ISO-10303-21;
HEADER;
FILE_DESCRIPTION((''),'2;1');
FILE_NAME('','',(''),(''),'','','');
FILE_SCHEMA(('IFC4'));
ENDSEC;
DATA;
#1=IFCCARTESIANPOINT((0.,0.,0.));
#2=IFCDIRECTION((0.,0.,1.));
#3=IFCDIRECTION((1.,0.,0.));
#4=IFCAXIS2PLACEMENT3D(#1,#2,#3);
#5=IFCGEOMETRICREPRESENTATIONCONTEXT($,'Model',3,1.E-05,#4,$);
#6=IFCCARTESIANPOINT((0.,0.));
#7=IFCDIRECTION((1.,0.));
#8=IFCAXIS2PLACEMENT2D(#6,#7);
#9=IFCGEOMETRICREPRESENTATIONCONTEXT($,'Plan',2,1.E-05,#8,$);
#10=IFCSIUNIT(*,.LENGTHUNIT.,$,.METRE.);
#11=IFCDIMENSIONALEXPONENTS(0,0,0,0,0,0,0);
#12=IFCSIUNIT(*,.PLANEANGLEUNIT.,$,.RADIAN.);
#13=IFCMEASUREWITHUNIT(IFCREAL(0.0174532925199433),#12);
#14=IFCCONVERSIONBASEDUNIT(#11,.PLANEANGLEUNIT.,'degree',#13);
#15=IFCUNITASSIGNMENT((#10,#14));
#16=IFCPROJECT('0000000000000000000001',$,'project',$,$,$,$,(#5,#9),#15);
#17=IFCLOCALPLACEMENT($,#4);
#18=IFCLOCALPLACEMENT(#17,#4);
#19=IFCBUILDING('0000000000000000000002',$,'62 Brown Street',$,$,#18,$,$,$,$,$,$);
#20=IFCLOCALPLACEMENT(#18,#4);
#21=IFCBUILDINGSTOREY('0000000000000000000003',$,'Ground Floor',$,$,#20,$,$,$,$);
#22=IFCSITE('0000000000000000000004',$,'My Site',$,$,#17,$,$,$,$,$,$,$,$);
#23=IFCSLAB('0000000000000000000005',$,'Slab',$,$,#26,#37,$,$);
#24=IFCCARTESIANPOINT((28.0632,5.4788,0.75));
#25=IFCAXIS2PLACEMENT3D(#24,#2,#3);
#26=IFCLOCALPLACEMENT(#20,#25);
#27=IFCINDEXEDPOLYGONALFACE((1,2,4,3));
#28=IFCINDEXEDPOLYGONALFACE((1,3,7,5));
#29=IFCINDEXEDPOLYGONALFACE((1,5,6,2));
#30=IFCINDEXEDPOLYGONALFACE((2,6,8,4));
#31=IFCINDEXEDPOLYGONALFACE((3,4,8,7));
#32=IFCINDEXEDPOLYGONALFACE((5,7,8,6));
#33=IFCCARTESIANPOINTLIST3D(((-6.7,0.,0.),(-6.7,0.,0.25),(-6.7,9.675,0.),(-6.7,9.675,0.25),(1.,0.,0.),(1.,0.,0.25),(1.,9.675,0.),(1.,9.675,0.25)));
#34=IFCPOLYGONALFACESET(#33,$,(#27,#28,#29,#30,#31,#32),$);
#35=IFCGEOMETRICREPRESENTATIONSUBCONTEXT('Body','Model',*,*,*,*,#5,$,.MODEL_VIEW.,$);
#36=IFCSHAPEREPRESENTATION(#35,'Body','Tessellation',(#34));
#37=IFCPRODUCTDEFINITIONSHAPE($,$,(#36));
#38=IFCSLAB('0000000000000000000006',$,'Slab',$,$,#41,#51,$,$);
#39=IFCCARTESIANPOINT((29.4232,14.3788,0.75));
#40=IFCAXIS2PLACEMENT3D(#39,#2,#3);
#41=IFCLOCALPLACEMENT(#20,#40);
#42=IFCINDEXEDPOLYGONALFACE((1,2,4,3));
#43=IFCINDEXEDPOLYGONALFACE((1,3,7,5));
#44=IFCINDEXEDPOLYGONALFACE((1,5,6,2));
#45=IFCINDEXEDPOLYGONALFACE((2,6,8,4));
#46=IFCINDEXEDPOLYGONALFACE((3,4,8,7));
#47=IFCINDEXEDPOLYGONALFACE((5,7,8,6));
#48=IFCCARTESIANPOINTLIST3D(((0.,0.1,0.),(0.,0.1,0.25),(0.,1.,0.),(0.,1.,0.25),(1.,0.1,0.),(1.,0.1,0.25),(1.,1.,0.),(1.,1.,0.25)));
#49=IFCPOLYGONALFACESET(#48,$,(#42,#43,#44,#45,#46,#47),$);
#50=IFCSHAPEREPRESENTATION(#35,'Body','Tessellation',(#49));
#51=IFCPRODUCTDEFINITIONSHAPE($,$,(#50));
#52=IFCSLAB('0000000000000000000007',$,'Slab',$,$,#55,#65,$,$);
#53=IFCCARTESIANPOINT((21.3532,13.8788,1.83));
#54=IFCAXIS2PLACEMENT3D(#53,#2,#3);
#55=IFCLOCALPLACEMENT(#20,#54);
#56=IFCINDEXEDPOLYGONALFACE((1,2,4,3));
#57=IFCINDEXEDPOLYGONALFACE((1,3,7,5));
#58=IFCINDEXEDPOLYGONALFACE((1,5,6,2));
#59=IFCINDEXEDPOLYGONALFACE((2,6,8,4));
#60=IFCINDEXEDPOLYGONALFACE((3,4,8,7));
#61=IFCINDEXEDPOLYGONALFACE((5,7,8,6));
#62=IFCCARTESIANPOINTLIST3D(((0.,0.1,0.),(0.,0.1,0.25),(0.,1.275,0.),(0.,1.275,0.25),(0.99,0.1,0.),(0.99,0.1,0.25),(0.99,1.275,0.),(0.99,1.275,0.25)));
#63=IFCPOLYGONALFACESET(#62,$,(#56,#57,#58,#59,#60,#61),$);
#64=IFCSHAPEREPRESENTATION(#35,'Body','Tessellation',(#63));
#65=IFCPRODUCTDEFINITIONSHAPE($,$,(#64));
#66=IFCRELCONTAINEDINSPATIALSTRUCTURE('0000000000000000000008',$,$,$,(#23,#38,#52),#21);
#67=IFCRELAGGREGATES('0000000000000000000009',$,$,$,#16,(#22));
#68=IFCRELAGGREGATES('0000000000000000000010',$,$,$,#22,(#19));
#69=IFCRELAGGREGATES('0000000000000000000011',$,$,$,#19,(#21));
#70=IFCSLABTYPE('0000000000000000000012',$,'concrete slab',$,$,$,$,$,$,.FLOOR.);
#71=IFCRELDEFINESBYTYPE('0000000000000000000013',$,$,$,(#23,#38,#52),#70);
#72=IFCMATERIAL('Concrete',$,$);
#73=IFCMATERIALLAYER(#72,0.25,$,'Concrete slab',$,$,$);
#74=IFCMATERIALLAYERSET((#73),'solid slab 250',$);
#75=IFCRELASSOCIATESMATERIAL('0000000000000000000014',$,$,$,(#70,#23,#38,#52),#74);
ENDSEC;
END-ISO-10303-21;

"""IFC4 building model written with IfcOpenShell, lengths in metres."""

from ifc_helpers import new_model, entity, si_unit, converted_unit, frame, origin_with_axes, origin_2d_with_axis, place, context, subcontext, project, spatial, line, indexed_curve, outline, extrude, material, layer, layer_set, layer_usage, type_object, element, save


model = new_model("IFC4")

# Units and contexts
model_context = context("Model", 3, precision=1e-05, world=origin_with_axes())
plan_context = context("Plan", 2, precision=1e-05, world=origin_2d_with_axis())
body_context_1 = subcontext(model_context, "Body", "Model", "MODEL_VIEW")
ifc_project = project(units=[si_unit("LENGTHUNIT", "METRE"), converted_unit("PLANEANGLEUNIT", "degree", entity("IfcReal", 0.0174532925199433), si_unit("PLANEANGLEUNIT", "RADIAN"), dimensions=[0, 0, 0, 0, 0, 0, 0])], contexts=[model_context, plan_context])

# Site, building, storey
site_placement = place(None, origin_with_axes())
site = spatial("IfcSite", under=ifc_project, at=site_placement, Name="My Site")
building_placement = place(site_placement, origin_with_axes())
building = spatial("IfcBuilding", under=site, at=building_placement, Name="62 Brown Street")
storey_placement = place(building_placement, origin_with_axes())
storey = spatial("IfcBuildingStorey", under=building, at=storey_placement, Name="Ground Floor")

# Shared definitions
ifc_material_1 = material(Name="Concrete")

# Slabs
ifc_layer_1 = layer(ifc_material_1, 0.25, Name="Concrete slab")
ifc_layer_set_1 = layer_set([ifc_layer_1], Name="solid slab 250")
slab_type = type_object("IfcSlabType", Name="concrete slab", PredefinedType="FLOOR", material=ifc_layer_set_1)
ifc_layer_usage_1 = layer_usage(ifc_layer_set_1, "AXIS3", "POSITIVE", 0.0)
slab_1_placement = place(storey_placement, frame((28.0632, 5.4788, 0.75), z_axis=(0.0, 0.0, 1.0), x_axis=(1.0, 0.0, 0.0)))
element("IfcSlab", 1, at=slab_1_placement, inside=storey, type_object=slab_type, material=ifc_layer_usage_1, Name="Slab", context=body_context_1, shape_type="SweptSolid", body=[
    extrude(outline(indexed_curve([(1.0, 9.675), (-6.7, 9.675), (-6.7, 0.0), (1.0, 0.0)], segments=[line(3, 2), line(2, 1), line(1, 4), line(4, 3)], self_intersect=False)), None, (0.0, 0.0, 1.0), 0.25),
])
ifc_layer_usage_2 = layer_usage(ifc_layer_set_1, "AXIS3", "POSITIVE", 0.0)
slab_2_placement = place(storey_placement, frame((29.4232, 14.3788, 0.75), z_axis=(0.0, 0.0, 1.0), x_axis=(1.0, 0.0, 0.0)))
element("IfcSlab", 2, at=slab_2_placement, inside=storey, type_object=slab_type, material=ifc_layer_usage_2, Name="Slab", context=body_context_1, shape_type="SweptSolid", body=[
    extrude(outline(indexed_curve([(1.0, 1.0), (1.0, 0.1), (0.0, 0.1), (0.0, 1.0)], segments=[line(3, 2), line(2, 1), line(1, 4), line(4, 3)], self_intersect=False)), None, (0.0, 0.0, 1.0), 0.25),
])
ifc_layer_usage_3 = layer_usage(ifc_layer_set_1, "AXIS3", "POSITIVE", 0.0)
slab_3_placement = place(storey_placement, frame((21.3532, 13.8788, 1.83), z_axis=(0.0, 0.0, 1.0), x_axis=(1.0, 0.0, 0.0)))
element("IfcSlab", 3, at=slab_3_placement, inside=storey, type_object=slab_type, material=ifc_layer_usage_3, Name="Slab", context=body_context_1, shape_type="SweptSolid", body=[
    extrude(outline(indexed_curve([(0.99, 1.275), (0.99, 0.1), (0.0, 0.1), (0.0, 1.275)], segments=[line(3, 2), line(2, 1), line(1, 4), line(4, 3)], self_intersect=False)), None, (0.0, 0.0, 1.0), 0.25),
])

save(model, "model.ifc")
